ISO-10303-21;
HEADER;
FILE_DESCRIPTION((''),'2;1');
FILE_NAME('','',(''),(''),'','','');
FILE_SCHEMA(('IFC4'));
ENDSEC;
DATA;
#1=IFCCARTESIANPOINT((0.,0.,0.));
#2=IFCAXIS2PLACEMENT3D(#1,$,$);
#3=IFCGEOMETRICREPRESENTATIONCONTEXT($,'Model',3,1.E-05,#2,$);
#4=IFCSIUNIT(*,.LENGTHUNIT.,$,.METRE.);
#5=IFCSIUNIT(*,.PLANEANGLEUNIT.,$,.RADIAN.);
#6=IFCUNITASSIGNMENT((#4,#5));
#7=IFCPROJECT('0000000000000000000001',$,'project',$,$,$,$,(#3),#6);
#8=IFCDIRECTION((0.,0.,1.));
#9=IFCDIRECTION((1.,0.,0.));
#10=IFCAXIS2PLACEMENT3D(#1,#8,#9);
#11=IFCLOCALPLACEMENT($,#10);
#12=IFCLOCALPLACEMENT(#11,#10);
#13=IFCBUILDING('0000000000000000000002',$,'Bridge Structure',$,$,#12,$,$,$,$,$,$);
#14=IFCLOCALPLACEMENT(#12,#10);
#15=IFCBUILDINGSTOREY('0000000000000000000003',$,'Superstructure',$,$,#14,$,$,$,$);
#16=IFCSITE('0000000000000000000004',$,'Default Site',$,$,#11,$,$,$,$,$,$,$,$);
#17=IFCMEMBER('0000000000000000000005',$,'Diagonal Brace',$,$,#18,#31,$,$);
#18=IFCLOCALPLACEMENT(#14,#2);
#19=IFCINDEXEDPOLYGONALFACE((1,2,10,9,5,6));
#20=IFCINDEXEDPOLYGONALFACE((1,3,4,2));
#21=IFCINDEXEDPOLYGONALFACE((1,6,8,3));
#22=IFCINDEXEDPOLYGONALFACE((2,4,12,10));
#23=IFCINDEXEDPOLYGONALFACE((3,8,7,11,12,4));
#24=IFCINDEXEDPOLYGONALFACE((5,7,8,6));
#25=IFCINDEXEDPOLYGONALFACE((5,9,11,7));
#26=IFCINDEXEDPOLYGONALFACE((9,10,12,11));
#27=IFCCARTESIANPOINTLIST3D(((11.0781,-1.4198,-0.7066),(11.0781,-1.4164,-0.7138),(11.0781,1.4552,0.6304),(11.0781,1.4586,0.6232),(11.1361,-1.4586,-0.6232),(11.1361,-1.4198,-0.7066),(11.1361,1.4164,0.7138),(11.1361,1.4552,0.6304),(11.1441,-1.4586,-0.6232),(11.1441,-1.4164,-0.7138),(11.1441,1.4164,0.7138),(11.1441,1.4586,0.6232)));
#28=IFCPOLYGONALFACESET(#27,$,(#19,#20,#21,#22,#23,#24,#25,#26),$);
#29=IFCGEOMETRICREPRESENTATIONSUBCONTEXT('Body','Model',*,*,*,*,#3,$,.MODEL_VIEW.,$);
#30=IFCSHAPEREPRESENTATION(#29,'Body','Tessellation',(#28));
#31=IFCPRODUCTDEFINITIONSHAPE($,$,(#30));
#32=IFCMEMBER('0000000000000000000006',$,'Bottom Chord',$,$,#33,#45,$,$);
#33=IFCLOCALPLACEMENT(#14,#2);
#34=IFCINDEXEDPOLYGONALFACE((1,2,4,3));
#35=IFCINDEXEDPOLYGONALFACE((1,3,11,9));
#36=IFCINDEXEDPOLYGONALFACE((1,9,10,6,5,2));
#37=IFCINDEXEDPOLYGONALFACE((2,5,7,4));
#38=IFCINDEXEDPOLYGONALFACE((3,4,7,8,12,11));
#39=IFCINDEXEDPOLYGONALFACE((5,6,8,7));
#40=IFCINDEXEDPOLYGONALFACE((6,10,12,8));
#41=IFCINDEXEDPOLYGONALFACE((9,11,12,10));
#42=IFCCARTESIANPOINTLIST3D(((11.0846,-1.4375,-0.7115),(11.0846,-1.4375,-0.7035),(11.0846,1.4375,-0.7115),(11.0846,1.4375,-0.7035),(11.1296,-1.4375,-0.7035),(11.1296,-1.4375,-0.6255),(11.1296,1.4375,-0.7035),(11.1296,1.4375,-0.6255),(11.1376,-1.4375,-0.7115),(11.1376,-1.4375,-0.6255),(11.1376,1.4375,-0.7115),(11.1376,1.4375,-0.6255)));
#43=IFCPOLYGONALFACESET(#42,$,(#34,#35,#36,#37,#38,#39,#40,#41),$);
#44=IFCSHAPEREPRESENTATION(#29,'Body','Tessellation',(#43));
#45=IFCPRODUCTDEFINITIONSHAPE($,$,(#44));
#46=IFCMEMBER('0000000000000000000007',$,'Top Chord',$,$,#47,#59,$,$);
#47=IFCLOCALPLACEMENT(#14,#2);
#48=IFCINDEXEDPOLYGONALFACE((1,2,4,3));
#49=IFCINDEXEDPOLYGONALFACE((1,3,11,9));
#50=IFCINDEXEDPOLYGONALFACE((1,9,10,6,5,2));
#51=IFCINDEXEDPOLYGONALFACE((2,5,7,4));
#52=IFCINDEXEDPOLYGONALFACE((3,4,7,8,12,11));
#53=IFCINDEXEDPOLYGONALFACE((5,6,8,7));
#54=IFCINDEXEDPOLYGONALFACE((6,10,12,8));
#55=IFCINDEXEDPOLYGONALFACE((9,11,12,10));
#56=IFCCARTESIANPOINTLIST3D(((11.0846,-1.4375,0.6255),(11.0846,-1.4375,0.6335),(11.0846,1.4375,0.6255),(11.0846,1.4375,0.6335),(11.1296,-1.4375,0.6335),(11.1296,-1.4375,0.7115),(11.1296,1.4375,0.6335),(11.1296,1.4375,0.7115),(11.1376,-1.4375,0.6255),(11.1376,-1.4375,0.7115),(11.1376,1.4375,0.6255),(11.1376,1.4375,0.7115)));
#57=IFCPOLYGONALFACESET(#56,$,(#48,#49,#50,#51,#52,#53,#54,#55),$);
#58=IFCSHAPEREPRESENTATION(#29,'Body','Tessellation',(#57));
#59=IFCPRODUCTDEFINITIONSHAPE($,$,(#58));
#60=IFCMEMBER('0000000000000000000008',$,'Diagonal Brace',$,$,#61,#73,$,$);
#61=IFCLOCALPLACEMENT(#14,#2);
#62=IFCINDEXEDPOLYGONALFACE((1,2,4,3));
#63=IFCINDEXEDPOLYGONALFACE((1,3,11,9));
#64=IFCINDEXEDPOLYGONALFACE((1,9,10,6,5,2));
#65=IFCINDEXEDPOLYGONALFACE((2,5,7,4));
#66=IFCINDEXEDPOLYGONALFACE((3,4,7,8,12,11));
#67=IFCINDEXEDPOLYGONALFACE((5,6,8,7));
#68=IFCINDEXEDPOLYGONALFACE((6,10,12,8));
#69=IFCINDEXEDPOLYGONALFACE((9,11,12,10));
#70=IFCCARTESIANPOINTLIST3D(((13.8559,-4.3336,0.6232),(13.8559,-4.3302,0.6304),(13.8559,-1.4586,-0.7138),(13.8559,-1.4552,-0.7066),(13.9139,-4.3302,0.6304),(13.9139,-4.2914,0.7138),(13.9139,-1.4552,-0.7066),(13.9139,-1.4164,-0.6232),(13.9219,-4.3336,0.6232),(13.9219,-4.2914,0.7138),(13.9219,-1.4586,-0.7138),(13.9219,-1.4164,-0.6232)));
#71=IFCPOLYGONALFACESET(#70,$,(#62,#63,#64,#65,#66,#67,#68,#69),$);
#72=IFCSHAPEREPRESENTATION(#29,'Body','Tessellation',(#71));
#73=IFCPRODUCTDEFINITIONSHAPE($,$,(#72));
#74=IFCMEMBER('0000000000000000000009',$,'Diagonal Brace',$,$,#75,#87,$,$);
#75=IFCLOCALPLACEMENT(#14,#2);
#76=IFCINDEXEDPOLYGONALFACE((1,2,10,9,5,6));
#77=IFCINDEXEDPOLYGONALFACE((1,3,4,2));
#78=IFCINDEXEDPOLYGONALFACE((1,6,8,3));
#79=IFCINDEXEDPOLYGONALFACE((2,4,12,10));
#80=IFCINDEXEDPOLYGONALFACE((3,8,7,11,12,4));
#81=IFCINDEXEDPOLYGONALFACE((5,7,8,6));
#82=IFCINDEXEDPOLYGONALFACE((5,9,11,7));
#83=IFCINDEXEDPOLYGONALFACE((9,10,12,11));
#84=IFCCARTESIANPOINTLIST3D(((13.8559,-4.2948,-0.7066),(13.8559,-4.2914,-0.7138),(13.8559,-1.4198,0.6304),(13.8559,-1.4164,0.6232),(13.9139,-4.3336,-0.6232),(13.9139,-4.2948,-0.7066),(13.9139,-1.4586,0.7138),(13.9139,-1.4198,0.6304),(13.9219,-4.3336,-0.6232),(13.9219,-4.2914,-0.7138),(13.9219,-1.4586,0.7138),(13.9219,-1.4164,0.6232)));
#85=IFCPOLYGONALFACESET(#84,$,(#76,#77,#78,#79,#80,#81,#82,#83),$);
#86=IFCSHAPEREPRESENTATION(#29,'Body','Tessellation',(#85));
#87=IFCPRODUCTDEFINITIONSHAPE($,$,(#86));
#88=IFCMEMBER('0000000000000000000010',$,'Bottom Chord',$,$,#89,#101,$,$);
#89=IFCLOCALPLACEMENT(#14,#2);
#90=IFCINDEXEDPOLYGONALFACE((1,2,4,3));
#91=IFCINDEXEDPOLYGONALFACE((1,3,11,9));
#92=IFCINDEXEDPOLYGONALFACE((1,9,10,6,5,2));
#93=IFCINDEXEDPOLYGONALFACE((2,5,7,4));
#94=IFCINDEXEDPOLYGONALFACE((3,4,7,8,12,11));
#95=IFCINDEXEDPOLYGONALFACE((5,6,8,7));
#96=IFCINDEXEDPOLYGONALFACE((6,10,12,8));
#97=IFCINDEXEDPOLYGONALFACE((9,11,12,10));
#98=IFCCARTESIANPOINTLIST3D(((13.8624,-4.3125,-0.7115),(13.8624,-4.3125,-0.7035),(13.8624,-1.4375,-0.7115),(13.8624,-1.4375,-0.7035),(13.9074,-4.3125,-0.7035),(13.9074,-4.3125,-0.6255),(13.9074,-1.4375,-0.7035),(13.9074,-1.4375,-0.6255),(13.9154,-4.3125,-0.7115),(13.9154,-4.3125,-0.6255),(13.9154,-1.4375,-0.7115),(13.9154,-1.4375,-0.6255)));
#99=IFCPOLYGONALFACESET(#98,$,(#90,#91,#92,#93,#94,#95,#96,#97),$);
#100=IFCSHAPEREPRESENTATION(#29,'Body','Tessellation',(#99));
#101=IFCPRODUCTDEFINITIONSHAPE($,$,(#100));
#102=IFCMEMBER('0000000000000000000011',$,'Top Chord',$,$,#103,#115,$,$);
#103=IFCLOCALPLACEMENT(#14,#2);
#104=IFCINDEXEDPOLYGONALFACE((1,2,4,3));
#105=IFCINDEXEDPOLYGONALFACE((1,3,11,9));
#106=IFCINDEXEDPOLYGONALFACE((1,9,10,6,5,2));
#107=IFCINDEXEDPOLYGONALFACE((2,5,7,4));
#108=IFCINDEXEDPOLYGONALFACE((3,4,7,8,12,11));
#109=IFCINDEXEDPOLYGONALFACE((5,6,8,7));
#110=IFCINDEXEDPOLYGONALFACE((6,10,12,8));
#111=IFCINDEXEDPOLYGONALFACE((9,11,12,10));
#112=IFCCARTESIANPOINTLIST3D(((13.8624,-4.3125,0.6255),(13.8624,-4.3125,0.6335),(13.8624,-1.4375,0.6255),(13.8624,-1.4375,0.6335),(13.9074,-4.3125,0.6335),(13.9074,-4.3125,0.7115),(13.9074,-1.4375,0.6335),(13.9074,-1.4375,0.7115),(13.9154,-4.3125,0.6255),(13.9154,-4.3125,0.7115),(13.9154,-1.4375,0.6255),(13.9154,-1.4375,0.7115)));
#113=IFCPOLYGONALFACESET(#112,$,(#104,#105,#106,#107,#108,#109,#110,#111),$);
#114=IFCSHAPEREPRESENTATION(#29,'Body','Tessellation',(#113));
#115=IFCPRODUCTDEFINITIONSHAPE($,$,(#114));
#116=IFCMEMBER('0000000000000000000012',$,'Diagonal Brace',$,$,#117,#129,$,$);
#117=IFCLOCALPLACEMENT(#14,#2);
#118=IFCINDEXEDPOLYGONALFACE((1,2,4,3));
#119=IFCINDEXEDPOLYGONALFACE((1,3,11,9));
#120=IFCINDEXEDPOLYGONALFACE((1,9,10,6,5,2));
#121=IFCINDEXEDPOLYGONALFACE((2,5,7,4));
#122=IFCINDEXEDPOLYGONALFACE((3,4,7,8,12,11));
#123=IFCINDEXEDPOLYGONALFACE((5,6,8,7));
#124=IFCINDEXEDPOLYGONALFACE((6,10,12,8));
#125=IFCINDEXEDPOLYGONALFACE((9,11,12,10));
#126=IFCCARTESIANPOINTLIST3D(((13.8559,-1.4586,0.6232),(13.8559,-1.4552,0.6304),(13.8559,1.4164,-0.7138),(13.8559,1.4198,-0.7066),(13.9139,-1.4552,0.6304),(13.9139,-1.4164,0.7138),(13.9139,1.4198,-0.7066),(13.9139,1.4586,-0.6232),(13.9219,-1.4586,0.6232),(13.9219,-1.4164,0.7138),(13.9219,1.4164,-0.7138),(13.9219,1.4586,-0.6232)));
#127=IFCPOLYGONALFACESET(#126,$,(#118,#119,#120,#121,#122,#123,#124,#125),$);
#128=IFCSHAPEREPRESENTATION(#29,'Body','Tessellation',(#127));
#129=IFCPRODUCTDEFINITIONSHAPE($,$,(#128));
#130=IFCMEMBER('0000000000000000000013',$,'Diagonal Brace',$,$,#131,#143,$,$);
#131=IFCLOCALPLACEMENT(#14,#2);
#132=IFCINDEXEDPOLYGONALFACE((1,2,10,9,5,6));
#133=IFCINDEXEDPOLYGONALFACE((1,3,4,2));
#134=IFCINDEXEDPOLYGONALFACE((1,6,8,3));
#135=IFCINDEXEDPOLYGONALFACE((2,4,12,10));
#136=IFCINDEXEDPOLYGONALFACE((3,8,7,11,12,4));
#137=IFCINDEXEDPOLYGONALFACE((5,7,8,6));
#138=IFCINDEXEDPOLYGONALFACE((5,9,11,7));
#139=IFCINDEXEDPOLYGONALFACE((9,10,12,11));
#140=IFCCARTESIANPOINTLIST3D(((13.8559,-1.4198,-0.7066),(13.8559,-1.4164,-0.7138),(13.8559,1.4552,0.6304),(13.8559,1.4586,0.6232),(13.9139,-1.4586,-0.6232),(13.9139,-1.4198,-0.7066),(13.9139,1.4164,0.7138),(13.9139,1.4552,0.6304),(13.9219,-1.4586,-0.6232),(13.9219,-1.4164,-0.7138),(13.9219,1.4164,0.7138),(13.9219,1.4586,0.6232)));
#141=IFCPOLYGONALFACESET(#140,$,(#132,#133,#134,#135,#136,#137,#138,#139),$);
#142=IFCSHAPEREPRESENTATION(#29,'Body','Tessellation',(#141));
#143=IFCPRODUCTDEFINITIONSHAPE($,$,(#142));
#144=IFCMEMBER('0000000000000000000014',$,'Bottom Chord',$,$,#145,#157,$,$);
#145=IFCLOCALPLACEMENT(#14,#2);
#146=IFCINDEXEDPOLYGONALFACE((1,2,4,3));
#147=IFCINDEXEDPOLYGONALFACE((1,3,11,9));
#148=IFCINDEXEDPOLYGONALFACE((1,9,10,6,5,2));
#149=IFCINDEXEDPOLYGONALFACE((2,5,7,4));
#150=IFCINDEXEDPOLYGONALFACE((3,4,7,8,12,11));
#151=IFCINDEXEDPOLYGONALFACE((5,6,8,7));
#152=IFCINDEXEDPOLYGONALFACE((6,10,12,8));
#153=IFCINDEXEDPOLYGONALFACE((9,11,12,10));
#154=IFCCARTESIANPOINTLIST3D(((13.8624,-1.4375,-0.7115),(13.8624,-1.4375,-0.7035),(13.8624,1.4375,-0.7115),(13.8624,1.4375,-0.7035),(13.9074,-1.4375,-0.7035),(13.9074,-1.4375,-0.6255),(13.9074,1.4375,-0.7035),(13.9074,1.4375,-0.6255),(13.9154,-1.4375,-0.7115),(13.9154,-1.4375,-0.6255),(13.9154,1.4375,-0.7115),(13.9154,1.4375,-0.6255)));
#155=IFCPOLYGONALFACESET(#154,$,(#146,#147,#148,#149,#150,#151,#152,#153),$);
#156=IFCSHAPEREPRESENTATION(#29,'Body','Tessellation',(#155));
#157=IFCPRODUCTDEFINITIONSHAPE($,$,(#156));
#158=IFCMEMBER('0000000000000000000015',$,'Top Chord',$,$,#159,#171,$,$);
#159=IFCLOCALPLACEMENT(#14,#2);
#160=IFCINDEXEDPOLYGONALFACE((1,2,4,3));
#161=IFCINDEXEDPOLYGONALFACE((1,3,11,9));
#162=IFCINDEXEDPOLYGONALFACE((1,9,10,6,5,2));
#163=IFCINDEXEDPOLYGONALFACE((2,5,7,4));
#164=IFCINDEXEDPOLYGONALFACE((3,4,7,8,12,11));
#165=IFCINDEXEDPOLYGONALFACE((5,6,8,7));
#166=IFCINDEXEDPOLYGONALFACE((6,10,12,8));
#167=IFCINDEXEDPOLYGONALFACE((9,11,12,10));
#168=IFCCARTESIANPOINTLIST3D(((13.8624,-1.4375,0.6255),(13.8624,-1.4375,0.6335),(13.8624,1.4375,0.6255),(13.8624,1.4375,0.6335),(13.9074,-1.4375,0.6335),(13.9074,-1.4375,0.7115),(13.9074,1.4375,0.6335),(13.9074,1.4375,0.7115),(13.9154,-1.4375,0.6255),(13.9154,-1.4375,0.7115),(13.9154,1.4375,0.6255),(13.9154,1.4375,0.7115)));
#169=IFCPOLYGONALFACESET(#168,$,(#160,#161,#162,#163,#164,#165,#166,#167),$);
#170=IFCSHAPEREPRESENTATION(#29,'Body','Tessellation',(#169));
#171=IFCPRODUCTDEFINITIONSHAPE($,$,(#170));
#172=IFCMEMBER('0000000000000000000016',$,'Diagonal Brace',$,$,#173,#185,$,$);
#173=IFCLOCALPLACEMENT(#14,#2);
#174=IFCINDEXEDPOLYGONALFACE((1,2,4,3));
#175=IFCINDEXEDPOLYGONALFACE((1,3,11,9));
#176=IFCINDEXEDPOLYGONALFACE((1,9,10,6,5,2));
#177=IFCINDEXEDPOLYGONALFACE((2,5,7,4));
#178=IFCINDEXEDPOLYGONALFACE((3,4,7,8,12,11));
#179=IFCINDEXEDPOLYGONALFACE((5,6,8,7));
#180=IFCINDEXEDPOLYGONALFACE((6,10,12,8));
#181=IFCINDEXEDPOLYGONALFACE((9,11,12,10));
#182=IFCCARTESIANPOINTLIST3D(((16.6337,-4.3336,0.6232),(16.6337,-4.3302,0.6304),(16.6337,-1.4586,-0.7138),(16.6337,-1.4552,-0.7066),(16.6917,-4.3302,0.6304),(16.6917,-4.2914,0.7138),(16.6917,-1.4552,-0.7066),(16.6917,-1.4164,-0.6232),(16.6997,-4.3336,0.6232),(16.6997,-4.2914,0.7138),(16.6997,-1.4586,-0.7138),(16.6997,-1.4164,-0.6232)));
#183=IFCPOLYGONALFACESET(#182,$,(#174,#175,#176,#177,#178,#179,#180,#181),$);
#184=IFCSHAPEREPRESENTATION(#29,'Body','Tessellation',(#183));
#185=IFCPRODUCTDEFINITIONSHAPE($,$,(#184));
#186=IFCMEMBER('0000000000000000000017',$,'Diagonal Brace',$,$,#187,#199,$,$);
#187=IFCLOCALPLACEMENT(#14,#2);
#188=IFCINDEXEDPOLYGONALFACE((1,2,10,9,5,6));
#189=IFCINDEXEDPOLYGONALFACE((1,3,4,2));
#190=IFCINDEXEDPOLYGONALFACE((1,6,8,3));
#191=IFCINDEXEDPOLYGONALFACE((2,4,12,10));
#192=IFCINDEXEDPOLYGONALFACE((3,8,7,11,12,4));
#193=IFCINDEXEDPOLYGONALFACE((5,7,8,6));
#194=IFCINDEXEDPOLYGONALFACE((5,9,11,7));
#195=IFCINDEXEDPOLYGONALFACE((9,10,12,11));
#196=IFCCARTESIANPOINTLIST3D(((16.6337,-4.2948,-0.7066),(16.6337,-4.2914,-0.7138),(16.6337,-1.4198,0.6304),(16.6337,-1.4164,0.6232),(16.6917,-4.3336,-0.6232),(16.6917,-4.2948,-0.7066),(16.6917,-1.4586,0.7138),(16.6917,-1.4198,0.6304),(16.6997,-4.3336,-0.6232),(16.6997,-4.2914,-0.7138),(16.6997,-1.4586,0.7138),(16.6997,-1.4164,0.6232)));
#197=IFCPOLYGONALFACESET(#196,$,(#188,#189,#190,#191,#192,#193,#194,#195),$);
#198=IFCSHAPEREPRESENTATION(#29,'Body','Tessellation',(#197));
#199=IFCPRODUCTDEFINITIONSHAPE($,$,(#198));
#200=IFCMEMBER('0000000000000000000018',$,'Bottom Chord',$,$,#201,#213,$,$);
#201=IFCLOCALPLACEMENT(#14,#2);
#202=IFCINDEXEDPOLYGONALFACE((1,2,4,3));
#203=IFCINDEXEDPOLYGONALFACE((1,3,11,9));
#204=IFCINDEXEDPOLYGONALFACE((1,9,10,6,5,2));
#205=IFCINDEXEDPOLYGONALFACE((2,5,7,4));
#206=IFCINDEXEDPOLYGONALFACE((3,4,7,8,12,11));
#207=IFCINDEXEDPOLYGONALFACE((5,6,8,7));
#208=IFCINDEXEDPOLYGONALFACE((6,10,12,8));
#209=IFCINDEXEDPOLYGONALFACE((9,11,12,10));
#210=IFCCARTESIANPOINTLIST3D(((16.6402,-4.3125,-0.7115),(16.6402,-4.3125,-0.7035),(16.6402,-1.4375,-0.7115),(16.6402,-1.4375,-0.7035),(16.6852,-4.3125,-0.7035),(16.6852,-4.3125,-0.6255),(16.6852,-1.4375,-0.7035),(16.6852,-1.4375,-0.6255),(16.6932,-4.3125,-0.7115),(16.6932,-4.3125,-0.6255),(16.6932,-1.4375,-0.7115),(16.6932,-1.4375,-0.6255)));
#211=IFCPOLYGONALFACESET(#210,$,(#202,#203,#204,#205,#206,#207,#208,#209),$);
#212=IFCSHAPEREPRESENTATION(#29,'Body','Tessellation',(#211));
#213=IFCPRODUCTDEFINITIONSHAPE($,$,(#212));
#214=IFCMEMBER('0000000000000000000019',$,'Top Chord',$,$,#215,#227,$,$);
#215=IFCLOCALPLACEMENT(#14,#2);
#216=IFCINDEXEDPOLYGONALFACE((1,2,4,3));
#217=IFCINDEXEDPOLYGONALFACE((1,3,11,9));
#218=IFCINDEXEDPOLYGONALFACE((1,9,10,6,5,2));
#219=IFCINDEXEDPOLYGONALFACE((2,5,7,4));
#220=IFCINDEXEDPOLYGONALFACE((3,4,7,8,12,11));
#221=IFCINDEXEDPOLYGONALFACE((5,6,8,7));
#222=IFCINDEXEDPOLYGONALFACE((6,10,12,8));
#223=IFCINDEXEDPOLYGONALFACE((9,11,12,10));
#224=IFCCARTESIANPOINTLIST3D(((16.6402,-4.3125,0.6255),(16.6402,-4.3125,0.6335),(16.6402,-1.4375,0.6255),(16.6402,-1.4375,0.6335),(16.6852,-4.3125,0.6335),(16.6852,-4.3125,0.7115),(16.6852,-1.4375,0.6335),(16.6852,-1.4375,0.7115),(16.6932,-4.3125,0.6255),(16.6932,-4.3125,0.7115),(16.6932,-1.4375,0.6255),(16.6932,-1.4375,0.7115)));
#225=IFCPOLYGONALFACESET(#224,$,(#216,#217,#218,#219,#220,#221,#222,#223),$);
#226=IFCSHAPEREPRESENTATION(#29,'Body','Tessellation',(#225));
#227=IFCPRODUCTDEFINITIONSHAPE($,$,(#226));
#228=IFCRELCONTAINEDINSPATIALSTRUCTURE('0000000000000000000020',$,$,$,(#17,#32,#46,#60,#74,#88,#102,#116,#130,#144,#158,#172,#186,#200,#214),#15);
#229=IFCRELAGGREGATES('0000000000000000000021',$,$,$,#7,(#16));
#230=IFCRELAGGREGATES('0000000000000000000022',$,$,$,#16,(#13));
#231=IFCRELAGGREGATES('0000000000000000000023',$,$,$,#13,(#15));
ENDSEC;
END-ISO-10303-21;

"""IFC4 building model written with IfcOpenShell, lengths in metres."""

from ifc_helpers import new_model, si_unit, frame, origin, origin_with_axes, origin_2d_with_axis, place, context, subcontext, project, spatial, l_section, extrude, element, save


model = new_model("IFC4")

# Units and contexts
model_context = context("Model", 3, precision=1e-05, world=origin())
body_context = subcontext(model_context, "Body", "Model", "MODEL_VIEW")
ifc_project = project(units=[si_unit("LENGTHUNIT", "METRE"), si_unit("PLANEANGLEUNIT", "RADIAN")], contexts=[model_context])

# Site, building, storey
site_placement = place(None, origin_with_axes())
site = spatial("IfcSite", under=ifc_project, at=site_placement, Name="Default Site")
building_placement = place(site_placement, origin_with_axes())
building = spatial("IfcBuilding", under=site, at=building_placement, Name="Bridge Structure")
storey_placement = place(building_placement, origin_with_axes())
storey = spatial("IfcBuildingStorey", under=building, at=storey_placement, Name="Superstructure")

# Members
member_placement = place(storey_placement, frame((11.1111, -1.4375, -0.6685), z_axis=(0.0, 0.906746, 0.421676), x_axis=(-1.0, 0.0, 0.0)))
element("IfcMember", 1, at=member_placement, inside=storey, Name="Diagonal Brace", context=body_context, shape_type="SweptSolid", body=[
    extrude(l_section(Depth=0.1, Width=0.066, Thickness=0.008, at=origin_2d_with_axis()), origin_with_axes(), (0.0, 0.0, 1.0), 3.1707),
])
for number, where, z_axis, x_axis, name in (
    (2, (11.1111, -1.4375, -0.6685), (0.0, 1.0, 0.0), (-1.0, 0.0, 0.0), "Bottom Chord"),
    (3, (11.1111, -1.4375, 0.6685), (0.0, 1.0, 0.0), (-1.0, 0.0, 0.0), "Top Chord"),
):
    element("IfcMember", number, at=place(storey_placement, frame(where, z_axis=z_axis, x_axis=x_axis)), inside=storey, Name=name, context=body_context, shape_type="SweptSolid", body=[
        extrude(l_section(Depth=0.086, Width=0.053, Thickness=0.008, at=origin_2d_with_axis()), origin_with_axes(), (0.0, 0.0, 1.0), 2.875),
    ])
for number, where, z_axis, x_axis, name in (
    (4, (13.8889, -4.3125, 0.6685), (0.0, 0.906746, -0.421676), (-1.0, 0.0, 0.0), "Diagonal Brace"),
    (5, (13.8889, -4.3125, -0.6685), (0.0, 0.906746, 0.421676), (-1.0, 0.0, 0.0), "Diagonal Brace"),
):
    element("IfcMember", number, at=place(storey_placement, frame(where, z_axis=z_axis, x_axis=x_axis)), inside=storey, Name=name, context=body_context, shape_type="SweptSolid", body=[
        extrude(l_section(Depth=0.1, Width=0.066, Thickness=0.008, at=origin_2d_with_axis()), origin_with_axes(), (0.0, 0.0, 1.0), 3.1707),
    ])
for number, where, z_axis, x_axis, name in (
    (6, (13.8889, -4.3125, -0.6685), (0.0, 1.0, 0.0), (-1.0, 0.0, 0.0), "Bottom Chord"),
    (7, (13.8889, -4.3125, 0.6685), (0.0, 1.0, 0.0), (-1.0, 0.0, 0.0), "Top Chord"),
):
    element("IfcMember", number, at=place(storey_placement, frame(where, z_axis=z_axis, x_axis=x_axis)), inside=storey, Name=name, context=body_context, shape_type="SweptSolid", body=[
        extrude(l_section(Depth=0.086, Width=0.053, Thickness=0.008, at=origin_2d_with_axis()), origin_with_axes(), (0.0, 0.0, 1.0), 2.875),
    ])
for number, where, z_axis, x_axis, name in (
    (8, (13.8889, -1.4375, 0.6685), (0.0, 0.906746, -0.421676), (-1.0, 0.0, 0.0), "Diagonal Brace"),
    (9, (13.8889, -1.4375, -0.6685), (0.0, 0.906746, 0.421676), (-1.0, 0.0, 0.0), "Diagonal Brace"),
):
    element("IfcMember", number, at=place(storey_placement, frame(where, z_axis=z_axis, x_axis=x_axis)), inside=storey, Name=name, context=body_context, shape_type="SweptSolid", body=[
        extrude(l_section(Depth=0.1, Width=0.066, Thickness=0.008, at=origin_2d_with_axis()), origin_with_axes(), (0.0, 0.0, 1.0), 3.1707),
    ])
for number, where, z_axis, x_axis, name in (
    (10, (13.8889, -1.4375, -0.6685), (0.0, 1.0, 0.0), (-1.0, 0.0, 0.0), "Bottom Chord"),
    (11, (13.8889, -1.4375, 0.6685), (0.0, 1.0, 0.0), (-1.0, 0.0, 0.0), "Top Chord"),
):
    element("IfcMember", number, at=place(storey_placement, frame(where, z_axis=z_axis, x_axis=x_axis)), inside=storey, Name=name, context=body_context, shape_type="SweptSolid", body=[
        extrude(l_section(Depth=0.086, Width=0.053, Thickness=0.008, at=origin_2d_with_axis()), origin_with_axes(), (0.0, 0.0, 1.0), 2.875),
    ])
for number, where, z_axis, x_axis, name in (
    (12, (16.6667, -4.3125, 0.6685), (0.0, 0.906746, -0.421676), (-1.0, 0.0, 0.0), "Diagonal Brace"),
    (13, (16.6667, -4.3125, -0.6685), (0.0, 0.906746, 0.421676), (-1.0, 0.0, 0.0), "Diagonal Brace"),
):
    element("IfcMember", number, at=place(storey_placement, frame(where, z_axis=z_axis, x_axis=x_axis)), inside=storey, Name=name, context=body_context, shape_type="SweptSolid", body=[
        extrude(l_section(Depth=0.1, Width=0.066, Thickness=0.008, at=origin_2d_with_axis()), origin_with_axes(), (0.0, 0.0, 1.0), 3.1707),
    ])
for number, where, z_axis, x_axis, name in (
    (14, (16.6667, -4.3125, -0.6685), (0.0, 1.0, 0.0), (-1.0, 0.0, 0.0), "Bottom Chord"),
    (15, (16.6667, -4.3125, 0.6685), (0.0, 1.0, 0.0), (-1.0, 0.0, 0.0), "Top Chord"),
):
    element("IfcMember", number, at=place(storey_placement, frame(where, z_axis=z_axis, x_axis=x_axis)), inside=storey, Name=name, context=body_context, shape_type="SweptSolid", body=[
        extrude(l_section(Depth=0.086, Width=0.053, Thickness=0.008, at=origin_2d_with_axis()), origin_with_axes(), (0.0, 0.0, 1.0), 2.875),
    ])

save(model, "model.ifc")
